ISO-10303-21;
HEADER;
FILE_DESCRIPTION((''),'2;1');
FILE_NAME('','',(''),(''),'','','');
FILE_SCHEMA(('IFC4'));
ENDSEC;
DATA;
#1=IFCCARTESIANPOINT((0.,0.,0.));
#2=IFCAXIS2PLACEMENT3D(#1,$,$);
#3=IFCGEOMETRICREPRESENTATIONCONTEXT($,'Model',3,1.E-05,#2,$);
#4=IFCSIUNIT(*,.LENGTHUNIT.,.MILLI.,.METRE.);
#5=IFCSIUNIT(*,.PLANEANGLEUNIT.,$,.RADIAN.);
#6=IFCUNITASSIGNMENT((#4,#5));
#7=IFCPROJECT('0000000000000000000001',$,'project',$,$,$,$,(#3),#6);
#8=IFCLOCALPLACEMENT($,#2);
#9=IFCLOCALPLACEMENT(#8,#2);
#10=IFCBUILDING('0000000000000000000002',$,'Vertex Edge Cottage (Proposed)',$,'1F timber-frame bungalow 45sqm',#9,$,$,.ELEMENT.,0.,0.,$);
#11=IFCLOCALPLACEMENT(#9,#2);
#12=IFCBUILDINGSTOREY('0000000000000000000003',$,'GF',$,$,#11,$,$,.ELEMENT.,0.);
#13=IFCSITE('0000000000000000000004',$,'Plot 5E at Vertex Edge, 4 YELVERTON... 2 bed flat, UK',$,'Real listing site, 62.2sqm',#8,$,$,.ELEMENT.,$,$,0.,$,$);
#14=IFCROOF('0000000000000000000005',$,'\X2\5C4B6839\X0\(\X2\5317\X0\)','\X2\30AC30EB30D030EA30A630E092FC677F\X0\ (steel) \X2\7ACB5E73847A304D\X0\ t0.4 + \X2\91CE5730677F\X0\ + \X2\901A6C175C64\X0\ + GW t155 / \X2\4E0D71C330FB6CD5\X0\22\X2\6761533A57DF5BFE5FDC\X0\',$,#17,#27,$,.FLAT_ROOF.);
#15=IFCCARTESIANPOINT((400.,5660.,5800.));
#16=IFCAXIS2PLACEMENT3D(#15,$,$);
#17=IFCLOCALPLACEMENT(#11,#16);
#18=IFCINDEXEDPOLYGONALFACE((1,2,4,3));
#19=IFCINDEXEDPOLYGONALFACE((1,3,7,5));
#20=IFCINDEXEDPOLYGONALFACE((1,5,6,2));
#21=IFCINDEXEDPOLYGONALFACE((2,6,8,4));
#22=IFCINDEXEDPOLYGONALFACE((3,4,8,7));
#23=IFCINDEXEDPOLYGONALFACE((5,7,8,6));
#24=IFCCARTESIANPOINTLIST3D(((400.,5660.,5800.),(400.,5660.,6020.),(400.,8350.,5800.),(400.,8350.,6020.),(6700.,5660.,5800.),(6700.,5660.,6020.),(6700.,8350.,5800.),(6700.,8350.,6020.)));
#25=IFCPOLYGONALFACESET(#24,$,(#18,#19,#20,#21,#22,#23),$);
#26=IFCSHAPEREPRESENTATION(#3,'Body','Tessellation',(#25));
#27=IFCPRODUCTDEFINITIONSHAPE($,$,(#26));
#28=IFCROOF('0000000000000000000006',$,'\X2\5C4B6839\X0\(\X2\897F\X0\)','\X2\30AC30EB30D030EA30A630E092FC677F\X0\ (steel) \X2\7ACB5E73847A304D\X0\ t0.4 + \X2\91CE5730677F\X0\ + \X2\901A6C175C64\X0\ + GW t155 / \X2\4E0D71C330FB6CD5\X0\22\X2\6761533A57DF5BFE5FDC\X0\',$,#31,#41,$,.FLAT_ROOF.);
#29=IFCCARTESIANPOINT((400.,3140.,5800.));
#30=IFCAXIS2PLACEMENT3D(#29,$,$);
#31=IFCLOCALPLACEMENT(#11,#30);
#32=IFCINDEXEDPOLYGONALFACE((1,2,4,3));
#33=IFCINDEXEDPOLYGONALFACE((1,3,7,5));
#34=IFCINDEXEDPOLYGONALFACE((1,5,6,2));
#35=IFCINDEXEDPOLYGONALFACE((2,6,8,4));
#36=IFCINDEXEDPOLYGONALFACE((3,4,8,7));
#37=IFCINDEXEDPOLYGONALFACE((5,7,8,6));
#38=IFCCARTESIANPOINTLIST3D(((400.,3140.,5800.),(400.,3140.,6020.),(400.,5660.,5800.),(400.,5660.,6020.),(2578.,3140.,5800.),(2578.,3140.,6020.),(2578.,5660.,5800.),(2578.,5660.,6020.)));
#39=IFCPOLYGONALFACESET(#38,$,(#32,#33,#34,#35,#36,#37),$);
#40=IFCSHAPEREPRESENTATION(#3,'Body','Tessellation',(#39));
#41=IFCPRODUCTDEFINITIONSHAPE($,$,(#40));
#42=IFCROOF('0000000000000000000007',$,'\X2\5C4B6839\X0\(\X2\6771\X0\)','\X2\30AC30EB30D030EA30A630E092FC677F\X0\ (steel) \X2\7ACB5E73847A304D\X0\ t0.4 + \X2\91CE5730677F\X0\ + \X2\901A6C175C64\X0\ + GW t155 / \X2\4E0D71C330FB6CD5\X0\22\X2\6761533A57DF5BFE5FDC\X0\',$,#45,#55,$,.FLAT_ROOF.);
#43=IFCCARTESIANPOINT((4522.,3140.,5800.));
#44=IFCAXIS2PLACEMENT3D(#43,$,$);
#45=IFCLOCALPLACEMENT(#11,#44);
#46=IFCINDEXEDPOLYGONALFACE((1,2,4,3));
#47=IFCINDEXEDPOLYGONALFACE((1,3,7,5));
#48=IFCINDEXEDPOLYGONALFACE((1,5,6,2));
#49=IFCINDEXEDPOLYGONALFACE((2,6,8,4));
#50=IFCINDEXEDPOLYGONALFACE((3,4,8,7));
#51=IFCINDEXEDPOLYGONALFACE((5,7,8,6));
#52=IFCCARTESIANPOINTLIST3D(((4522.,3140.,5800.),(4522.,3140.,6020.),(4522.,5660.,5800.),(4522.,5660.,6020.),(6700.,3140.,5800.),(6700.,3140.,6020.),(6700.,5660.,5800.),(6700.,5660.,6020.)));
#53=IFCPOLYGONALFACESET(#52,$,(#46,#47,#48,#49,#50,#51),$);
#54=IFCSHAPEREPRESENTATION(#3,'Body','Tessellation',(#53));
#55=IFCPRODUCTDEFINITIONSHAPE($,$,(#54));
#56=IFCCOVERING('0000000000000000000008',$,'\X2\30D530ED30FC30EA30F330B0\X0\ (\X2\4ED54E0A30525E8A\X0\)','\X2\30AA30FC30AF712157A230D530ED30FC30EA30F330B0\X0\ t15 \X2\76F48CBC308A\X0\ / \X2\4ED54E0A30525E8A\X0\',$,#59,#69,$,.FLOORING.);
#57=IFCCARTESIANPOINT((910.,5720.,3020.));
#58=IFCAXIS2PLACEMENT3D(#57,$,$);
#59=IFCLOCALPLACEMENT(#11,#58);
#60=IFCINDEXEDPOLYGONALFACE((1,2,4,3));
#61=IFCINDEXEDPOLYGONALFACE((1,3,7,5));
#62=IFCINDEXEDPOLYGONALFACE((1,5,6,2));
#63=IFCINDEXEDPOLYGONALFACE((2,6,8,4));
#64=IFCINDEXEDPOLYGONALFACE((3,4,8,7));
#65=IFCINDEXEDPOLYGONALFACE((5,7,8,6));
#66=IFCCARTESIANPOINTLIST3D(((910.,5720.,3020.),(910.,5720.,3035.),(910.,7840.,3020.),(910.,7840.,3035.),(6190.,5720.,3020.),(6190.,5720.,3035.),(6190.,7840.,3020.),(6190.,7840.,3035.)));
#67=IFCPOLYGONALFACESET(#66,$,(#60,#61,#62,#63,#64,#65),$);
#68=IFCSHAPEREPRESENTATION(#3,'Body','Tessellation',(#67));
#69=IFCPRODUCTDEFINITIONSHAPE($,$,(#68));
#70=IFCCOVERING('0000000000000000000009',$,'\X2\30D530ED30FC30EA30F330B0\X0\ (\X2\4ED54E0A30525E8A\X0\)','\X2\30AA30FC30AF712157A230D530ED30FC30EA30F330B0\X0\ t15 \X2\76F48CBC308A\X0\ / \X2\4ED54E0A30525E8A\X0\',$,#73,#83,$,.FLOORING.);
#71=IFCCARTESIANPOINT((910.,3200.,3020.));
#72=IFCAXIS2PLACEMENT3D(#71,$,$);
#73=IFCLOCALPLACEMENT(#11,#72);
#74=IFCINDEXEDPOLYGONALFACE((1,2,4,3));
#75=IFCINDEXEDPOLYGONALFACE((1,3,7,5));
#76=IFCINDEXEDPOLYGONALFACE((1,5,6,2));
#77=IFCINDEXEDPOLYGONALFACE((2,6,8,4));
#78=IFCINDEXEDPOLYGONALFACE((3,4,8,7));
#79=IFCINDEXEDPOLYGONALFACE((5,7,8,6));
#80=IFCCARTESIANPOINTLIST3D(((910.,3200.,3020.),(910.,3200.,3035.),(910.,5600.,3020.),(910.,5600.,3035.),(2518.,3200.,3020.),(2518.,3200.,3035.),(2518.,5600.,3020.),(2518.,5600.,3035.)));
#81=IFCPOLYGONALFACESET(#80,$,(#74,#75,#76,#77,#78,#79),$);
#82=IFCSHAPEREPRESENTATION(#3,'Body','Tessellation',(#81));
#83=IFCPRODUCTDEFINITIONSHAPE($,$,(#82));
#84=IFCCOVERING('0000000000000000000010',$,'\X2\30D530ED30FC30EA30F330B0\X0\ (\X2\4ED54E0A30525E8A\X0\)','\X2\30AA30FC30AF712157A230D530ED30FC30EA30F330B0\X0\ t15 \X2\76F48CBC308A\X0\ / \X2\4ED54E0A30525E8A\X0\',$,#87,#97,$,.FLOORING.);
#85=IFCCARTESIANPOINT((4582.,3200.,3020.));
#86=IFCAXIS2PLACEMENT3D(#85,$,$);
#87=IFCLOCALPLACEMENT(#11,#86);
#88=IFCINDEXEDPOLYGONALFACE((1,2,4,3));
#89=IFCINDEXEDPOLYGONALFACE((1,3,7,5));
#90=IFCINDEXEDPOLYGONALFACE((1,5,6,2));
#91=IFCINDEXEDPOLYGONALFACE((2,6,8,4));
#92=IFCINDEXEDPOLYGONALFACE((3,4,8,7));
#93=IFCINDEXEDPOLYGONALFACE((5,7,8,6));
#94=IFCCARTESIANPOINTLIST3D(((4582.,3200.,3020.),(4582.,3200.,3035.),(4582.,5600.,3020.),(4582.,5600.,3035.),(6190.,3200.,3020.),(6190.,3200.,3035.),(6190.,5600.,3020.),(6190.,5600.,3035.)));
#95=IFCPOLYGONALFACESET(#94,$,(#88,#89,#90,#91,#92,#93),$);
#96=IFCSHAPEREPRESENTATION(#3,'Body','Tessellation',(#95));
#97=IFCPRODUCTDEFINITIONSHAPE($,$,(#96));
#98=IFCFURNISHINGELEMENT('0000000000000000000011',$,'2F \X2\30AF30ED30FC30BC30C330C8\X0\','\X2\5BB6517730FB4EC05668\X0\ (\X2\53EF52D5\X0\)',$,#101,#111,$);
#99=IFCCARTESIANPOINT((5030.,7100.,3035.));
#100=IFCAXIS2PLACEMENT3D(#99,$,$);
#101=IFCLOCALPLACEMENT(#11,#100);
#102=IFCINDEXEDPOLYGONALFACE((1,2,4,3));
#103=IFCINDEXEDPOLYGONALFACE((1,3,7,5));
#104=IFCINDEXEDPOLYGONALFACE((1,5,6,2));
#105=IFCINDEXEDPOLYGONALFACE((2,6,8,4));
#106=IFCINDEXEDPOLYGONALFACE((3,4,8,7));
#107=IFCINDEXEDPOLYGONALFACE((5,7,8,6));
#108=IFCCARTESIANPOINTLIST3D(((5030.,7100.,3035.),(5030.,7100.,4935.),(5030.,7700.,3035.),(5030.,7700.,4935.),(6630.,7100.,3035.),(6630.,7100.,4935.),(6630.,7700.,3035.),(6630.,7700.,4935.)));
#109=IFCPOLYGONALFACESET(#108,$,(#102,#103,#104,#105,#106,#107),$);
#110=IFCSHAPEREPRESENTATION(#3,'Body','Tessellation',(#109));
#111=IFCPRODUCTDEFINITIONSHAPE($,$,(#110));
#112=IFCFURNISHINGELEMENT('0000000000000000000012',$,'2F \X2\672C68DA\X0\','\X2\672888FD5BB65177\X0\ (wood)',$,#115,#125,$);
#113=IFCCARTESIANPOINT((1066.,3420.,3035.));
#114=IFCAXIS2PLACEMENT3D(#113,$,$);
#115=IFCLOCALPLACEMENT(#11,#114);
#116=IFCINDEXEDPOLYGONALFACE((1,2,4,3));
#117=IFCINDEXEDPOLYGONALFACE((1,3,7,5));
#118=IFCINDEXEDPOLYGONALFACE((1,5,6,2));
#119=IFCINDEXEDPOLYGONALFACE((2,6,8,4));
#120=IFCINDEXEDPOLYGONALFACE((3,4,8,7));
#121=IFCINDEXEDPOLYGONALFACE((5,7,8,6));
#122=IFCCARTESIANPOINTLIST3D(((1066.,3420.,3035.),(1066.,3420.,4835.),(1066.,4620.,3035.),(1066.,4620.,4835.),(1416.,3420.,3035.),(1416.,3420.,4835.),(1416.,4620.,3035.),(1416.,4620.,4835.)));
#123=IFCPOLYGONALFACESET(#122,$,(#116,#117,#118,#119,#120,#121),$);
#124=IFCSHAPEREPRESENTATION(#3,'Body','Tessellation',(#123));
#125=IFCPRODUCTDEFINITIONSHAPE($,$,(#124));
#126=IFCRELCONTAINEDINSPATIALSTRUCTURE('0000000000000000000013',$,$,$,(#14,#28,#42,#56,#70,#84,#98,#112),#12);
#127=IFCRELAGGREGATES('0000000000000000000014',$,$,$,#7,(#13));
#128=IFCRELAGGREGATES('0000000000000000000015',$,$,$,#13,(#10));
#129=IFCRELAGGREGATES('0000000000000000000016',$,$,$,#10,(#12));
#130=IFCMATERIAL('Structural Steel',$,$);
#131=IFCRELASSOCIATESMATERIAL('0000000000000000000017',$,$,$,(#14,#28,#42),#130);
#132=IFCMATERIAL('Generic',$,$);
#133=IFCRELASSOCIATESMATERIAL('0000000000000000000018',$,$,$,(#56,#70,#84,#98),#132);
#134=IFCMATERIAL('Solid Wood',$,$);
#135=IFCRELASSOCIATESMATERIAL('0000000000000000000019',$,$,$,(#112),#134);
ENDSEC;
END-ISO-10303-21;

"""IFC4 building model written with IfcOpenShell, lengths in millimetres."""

from ifc_helpers import new_model, si_unit, frame, frame_2d, origin, place, context, project, spatial, rectangle, extrude, material, element, save


model = new_model("IFC4")

# Units and contexts
model_context = context("Model", 3, precision=1e-05, world=origin())
ifc_project = project(units=[si_unit("LENGTHUNIT", "METRE", prefix="MILLI"), si_unit("PLANEANGLEUNIT", "RADIAN")], contexts=[model_context])

# Site, building, storey
site_placement = place(None, origin())
site = spatial("IfcSite", under=ifc_project, at=site_placement, Name="Plot 5E at Vertex Edge, 4 YELVERTON... 2 bed flat, UK", ObjectType="Real listing site, 62.2sqm", CompositionType="ELEMENT", RefElevation=0.0)
building_placement = place(site_placement, origin())
building = spatial("IfcBuilding", under=site, at=building_placement, Name="Vertex Edge Cottage (Proposed)", ObjectType="1F timber-frame bungalow 45sqm", CompositionType="ELEMENT", ElevationOfRefHeight=0.0, ElevationOfTerrain=0.0)
storey_placement = place(building_placement, origin())
storey = spatial("IfcBuildingStorey", under=building, at=storey_placement, Name="GF", CompositionType="ELEMENT", Elevation=0.0)

# Shared definitions
ifc_material_1 = material(Name="Solid Wood")

# Roofs
ifc_material_2 = material(Name="Structural Steel")
for number, where, name in (
    (1, (400.0, 5660.0, 5800.0), "屋根(北)"),
):
    element("IfcRoof", number, at=place(storey_placement, frame(where)), inside=storey, material=ifc_material_2, Name=name, Description="ガルバリウム鋼板 (steel) 立平葺き t0.4 + 野地板 + 通気層 + GW t155 / 不燃・法22条区域対応", PredefinedType="FLAT_ROOF", context=model_context, shape_type="SweptSolid", body=[
        extrude(rectangle(XDim=6300.0, YDim=2690.0, at=frame_2d((3150.0, 1345.0))), frame((400.0, 5660.0, 5800.0)), (0.0, 0.0, 1.0), 220.0),
    ])
roof_1_placement = place(storey_placement, frame((400.0, 3140.0, 5800.0)))
element("IfcRoof", 2, at=roof_1_placement, inside=storey, material=ifc_material_2, Name="屋根(西)", Description="ガルバリウム鋼板 (steel) 立平葺き t0.4 + 野地板 + 通気層 + GW t155 / 不燃・法22条区域対応", PredefinedType="FLAT_ROOF", context=model_context, shape_type="SweptSolid", body=[
    extrude(rectangle(XDim=2178.0, YDim=2520.0, at=frame_2d((1089.0, 1260.0))), frame((400.0, 3140.0, 5800.0)), (0.0, 0.0, 1.0), 220.0),
])
roof_2_placement = place(storey_placement, frame((4522.0, 3140.0, 5800.0)))
element("IfcRoof", 3, at=roof_2_placement, inside=storey, material=ifc_material_2, Name="屋根(東)", Description="ガルバリウム鋼板 (steel) 立平葺き t0.4 + 野地板 + 通気層 + GW t155 / 不燃・法22条区域対応", PredefinedType="FLAT_ROOF", context=model_context, shape_type="SweptSolid", body=[
    extrude(rectangle(XDim=2178.0, YDim=2520.0, at=frame_2d((1089.0, 1260.0))), frame((4522.0, 3140.0, 5800.0)), (0.0, 0.0, 1.0), 220.0),
])

# Coverings
ifc_material_3 = material(Name="Generic")
covering_1_placement = place(storey_placement, frame((910.0, 5720.0, 3020.0)))
element("IfcCovering", 4, at=covering_1_placement, inside=storey, material=ifc_material_3, Name="フローリング (仕上げ床)", Description="オーク無垢フローリング t15 直貼り / 仕上げ床", PredefinedType="FLOORING", context=model_context, shape_type="SweptSolid", body=[
    extrude(rectangle(XDim=5280.0, YDim=2120.0, at=frame_2d((2640.0, 1060.0))), frame((910.0, 5720.0, 3020.0)), (0.0, 0.0, 1.0), 15.0),
])
covering_2_placement = place(storey_placement, frame((910.0, 3200.0, 3020.0)))
element("IfcCovering", 5, at=covering_2_placement, inside=storey, material=ifc_material_3, Name="フローリング (仕上げ床)", Description="オーク無垢フローリング t15 直貼り / 仕上げ床", PredefinedType="FLOORING", context=model_context, shape_type="SweptSolid", body=[
    extrude(rectangle(XDim=1608.0, YDim=2400.0, at=frame_2d((804.0, 1200.0))), frame((910.0, 3200.0, 3020.0)), (0.0, 0.0, 1.0), 15.0),
])
covering_3_placement = place(storey_placement, frame((4582.0, 3200.0, 3020.0)))
element("IfcCovering", 6, at=covering_3_placement, inside=storey, material=ifc_material_3, Name="フローリング (仕上げ床)", Description="オーク無垢フローリング t15 直貼り / 仕上げ床", PredefinedType="FLOORING", context=model_context, shape_type="SweptSolid", body=[
    extrude(rectangle(XDim=1608.0, YDim=2400.0, at=frame_2d((804.0, 1200.0))), frame((4582.0, 3200.0, 3020.0)), (0.0, 0.0, 1.0), 15.0),
])

# Furnishing elements
furnishing_1_placement = place(storey_placement, frame((5030.0, 7100.0, 3035.0)))
element("IfcFurnishingElement", 7, at=furnishing_1_placement, inside=storey, material=ifc_material_3, Name="2F クローゼット", Description="家具・什器 (可動)", context=model_context, shape_type="SweptSolid", body=[
    extrude(rectangle(XDim=1600.0, YDim=600.0, at=frame_2d((800.0, 300.0))), frame((5030.0, 7100.0, 3035.0)), (0.0, 0.0, 1.0), 1900.0),
])
furnishing_2_placement = place(storey_placement, frame((1066.0, 3420.0, 3035.0)))
element("IfcFurnishingElement", 8, at=furnishing_2_placement, inside=storey, material=ifc_material_1, Name="2F 本棚", Description="木製家具 (wood)", context=model_context, shape_type="SweptSolid", body=[
    extrude(rectangle(XDim=350.0, YDim=1200.0, at=frame_2d((175.0, 600.0))), frame((1066.0, 3420.0, 3035.0)), (0.0, 0.0, 1.0), 1800.0),
])

save(model, "model.ifc")
